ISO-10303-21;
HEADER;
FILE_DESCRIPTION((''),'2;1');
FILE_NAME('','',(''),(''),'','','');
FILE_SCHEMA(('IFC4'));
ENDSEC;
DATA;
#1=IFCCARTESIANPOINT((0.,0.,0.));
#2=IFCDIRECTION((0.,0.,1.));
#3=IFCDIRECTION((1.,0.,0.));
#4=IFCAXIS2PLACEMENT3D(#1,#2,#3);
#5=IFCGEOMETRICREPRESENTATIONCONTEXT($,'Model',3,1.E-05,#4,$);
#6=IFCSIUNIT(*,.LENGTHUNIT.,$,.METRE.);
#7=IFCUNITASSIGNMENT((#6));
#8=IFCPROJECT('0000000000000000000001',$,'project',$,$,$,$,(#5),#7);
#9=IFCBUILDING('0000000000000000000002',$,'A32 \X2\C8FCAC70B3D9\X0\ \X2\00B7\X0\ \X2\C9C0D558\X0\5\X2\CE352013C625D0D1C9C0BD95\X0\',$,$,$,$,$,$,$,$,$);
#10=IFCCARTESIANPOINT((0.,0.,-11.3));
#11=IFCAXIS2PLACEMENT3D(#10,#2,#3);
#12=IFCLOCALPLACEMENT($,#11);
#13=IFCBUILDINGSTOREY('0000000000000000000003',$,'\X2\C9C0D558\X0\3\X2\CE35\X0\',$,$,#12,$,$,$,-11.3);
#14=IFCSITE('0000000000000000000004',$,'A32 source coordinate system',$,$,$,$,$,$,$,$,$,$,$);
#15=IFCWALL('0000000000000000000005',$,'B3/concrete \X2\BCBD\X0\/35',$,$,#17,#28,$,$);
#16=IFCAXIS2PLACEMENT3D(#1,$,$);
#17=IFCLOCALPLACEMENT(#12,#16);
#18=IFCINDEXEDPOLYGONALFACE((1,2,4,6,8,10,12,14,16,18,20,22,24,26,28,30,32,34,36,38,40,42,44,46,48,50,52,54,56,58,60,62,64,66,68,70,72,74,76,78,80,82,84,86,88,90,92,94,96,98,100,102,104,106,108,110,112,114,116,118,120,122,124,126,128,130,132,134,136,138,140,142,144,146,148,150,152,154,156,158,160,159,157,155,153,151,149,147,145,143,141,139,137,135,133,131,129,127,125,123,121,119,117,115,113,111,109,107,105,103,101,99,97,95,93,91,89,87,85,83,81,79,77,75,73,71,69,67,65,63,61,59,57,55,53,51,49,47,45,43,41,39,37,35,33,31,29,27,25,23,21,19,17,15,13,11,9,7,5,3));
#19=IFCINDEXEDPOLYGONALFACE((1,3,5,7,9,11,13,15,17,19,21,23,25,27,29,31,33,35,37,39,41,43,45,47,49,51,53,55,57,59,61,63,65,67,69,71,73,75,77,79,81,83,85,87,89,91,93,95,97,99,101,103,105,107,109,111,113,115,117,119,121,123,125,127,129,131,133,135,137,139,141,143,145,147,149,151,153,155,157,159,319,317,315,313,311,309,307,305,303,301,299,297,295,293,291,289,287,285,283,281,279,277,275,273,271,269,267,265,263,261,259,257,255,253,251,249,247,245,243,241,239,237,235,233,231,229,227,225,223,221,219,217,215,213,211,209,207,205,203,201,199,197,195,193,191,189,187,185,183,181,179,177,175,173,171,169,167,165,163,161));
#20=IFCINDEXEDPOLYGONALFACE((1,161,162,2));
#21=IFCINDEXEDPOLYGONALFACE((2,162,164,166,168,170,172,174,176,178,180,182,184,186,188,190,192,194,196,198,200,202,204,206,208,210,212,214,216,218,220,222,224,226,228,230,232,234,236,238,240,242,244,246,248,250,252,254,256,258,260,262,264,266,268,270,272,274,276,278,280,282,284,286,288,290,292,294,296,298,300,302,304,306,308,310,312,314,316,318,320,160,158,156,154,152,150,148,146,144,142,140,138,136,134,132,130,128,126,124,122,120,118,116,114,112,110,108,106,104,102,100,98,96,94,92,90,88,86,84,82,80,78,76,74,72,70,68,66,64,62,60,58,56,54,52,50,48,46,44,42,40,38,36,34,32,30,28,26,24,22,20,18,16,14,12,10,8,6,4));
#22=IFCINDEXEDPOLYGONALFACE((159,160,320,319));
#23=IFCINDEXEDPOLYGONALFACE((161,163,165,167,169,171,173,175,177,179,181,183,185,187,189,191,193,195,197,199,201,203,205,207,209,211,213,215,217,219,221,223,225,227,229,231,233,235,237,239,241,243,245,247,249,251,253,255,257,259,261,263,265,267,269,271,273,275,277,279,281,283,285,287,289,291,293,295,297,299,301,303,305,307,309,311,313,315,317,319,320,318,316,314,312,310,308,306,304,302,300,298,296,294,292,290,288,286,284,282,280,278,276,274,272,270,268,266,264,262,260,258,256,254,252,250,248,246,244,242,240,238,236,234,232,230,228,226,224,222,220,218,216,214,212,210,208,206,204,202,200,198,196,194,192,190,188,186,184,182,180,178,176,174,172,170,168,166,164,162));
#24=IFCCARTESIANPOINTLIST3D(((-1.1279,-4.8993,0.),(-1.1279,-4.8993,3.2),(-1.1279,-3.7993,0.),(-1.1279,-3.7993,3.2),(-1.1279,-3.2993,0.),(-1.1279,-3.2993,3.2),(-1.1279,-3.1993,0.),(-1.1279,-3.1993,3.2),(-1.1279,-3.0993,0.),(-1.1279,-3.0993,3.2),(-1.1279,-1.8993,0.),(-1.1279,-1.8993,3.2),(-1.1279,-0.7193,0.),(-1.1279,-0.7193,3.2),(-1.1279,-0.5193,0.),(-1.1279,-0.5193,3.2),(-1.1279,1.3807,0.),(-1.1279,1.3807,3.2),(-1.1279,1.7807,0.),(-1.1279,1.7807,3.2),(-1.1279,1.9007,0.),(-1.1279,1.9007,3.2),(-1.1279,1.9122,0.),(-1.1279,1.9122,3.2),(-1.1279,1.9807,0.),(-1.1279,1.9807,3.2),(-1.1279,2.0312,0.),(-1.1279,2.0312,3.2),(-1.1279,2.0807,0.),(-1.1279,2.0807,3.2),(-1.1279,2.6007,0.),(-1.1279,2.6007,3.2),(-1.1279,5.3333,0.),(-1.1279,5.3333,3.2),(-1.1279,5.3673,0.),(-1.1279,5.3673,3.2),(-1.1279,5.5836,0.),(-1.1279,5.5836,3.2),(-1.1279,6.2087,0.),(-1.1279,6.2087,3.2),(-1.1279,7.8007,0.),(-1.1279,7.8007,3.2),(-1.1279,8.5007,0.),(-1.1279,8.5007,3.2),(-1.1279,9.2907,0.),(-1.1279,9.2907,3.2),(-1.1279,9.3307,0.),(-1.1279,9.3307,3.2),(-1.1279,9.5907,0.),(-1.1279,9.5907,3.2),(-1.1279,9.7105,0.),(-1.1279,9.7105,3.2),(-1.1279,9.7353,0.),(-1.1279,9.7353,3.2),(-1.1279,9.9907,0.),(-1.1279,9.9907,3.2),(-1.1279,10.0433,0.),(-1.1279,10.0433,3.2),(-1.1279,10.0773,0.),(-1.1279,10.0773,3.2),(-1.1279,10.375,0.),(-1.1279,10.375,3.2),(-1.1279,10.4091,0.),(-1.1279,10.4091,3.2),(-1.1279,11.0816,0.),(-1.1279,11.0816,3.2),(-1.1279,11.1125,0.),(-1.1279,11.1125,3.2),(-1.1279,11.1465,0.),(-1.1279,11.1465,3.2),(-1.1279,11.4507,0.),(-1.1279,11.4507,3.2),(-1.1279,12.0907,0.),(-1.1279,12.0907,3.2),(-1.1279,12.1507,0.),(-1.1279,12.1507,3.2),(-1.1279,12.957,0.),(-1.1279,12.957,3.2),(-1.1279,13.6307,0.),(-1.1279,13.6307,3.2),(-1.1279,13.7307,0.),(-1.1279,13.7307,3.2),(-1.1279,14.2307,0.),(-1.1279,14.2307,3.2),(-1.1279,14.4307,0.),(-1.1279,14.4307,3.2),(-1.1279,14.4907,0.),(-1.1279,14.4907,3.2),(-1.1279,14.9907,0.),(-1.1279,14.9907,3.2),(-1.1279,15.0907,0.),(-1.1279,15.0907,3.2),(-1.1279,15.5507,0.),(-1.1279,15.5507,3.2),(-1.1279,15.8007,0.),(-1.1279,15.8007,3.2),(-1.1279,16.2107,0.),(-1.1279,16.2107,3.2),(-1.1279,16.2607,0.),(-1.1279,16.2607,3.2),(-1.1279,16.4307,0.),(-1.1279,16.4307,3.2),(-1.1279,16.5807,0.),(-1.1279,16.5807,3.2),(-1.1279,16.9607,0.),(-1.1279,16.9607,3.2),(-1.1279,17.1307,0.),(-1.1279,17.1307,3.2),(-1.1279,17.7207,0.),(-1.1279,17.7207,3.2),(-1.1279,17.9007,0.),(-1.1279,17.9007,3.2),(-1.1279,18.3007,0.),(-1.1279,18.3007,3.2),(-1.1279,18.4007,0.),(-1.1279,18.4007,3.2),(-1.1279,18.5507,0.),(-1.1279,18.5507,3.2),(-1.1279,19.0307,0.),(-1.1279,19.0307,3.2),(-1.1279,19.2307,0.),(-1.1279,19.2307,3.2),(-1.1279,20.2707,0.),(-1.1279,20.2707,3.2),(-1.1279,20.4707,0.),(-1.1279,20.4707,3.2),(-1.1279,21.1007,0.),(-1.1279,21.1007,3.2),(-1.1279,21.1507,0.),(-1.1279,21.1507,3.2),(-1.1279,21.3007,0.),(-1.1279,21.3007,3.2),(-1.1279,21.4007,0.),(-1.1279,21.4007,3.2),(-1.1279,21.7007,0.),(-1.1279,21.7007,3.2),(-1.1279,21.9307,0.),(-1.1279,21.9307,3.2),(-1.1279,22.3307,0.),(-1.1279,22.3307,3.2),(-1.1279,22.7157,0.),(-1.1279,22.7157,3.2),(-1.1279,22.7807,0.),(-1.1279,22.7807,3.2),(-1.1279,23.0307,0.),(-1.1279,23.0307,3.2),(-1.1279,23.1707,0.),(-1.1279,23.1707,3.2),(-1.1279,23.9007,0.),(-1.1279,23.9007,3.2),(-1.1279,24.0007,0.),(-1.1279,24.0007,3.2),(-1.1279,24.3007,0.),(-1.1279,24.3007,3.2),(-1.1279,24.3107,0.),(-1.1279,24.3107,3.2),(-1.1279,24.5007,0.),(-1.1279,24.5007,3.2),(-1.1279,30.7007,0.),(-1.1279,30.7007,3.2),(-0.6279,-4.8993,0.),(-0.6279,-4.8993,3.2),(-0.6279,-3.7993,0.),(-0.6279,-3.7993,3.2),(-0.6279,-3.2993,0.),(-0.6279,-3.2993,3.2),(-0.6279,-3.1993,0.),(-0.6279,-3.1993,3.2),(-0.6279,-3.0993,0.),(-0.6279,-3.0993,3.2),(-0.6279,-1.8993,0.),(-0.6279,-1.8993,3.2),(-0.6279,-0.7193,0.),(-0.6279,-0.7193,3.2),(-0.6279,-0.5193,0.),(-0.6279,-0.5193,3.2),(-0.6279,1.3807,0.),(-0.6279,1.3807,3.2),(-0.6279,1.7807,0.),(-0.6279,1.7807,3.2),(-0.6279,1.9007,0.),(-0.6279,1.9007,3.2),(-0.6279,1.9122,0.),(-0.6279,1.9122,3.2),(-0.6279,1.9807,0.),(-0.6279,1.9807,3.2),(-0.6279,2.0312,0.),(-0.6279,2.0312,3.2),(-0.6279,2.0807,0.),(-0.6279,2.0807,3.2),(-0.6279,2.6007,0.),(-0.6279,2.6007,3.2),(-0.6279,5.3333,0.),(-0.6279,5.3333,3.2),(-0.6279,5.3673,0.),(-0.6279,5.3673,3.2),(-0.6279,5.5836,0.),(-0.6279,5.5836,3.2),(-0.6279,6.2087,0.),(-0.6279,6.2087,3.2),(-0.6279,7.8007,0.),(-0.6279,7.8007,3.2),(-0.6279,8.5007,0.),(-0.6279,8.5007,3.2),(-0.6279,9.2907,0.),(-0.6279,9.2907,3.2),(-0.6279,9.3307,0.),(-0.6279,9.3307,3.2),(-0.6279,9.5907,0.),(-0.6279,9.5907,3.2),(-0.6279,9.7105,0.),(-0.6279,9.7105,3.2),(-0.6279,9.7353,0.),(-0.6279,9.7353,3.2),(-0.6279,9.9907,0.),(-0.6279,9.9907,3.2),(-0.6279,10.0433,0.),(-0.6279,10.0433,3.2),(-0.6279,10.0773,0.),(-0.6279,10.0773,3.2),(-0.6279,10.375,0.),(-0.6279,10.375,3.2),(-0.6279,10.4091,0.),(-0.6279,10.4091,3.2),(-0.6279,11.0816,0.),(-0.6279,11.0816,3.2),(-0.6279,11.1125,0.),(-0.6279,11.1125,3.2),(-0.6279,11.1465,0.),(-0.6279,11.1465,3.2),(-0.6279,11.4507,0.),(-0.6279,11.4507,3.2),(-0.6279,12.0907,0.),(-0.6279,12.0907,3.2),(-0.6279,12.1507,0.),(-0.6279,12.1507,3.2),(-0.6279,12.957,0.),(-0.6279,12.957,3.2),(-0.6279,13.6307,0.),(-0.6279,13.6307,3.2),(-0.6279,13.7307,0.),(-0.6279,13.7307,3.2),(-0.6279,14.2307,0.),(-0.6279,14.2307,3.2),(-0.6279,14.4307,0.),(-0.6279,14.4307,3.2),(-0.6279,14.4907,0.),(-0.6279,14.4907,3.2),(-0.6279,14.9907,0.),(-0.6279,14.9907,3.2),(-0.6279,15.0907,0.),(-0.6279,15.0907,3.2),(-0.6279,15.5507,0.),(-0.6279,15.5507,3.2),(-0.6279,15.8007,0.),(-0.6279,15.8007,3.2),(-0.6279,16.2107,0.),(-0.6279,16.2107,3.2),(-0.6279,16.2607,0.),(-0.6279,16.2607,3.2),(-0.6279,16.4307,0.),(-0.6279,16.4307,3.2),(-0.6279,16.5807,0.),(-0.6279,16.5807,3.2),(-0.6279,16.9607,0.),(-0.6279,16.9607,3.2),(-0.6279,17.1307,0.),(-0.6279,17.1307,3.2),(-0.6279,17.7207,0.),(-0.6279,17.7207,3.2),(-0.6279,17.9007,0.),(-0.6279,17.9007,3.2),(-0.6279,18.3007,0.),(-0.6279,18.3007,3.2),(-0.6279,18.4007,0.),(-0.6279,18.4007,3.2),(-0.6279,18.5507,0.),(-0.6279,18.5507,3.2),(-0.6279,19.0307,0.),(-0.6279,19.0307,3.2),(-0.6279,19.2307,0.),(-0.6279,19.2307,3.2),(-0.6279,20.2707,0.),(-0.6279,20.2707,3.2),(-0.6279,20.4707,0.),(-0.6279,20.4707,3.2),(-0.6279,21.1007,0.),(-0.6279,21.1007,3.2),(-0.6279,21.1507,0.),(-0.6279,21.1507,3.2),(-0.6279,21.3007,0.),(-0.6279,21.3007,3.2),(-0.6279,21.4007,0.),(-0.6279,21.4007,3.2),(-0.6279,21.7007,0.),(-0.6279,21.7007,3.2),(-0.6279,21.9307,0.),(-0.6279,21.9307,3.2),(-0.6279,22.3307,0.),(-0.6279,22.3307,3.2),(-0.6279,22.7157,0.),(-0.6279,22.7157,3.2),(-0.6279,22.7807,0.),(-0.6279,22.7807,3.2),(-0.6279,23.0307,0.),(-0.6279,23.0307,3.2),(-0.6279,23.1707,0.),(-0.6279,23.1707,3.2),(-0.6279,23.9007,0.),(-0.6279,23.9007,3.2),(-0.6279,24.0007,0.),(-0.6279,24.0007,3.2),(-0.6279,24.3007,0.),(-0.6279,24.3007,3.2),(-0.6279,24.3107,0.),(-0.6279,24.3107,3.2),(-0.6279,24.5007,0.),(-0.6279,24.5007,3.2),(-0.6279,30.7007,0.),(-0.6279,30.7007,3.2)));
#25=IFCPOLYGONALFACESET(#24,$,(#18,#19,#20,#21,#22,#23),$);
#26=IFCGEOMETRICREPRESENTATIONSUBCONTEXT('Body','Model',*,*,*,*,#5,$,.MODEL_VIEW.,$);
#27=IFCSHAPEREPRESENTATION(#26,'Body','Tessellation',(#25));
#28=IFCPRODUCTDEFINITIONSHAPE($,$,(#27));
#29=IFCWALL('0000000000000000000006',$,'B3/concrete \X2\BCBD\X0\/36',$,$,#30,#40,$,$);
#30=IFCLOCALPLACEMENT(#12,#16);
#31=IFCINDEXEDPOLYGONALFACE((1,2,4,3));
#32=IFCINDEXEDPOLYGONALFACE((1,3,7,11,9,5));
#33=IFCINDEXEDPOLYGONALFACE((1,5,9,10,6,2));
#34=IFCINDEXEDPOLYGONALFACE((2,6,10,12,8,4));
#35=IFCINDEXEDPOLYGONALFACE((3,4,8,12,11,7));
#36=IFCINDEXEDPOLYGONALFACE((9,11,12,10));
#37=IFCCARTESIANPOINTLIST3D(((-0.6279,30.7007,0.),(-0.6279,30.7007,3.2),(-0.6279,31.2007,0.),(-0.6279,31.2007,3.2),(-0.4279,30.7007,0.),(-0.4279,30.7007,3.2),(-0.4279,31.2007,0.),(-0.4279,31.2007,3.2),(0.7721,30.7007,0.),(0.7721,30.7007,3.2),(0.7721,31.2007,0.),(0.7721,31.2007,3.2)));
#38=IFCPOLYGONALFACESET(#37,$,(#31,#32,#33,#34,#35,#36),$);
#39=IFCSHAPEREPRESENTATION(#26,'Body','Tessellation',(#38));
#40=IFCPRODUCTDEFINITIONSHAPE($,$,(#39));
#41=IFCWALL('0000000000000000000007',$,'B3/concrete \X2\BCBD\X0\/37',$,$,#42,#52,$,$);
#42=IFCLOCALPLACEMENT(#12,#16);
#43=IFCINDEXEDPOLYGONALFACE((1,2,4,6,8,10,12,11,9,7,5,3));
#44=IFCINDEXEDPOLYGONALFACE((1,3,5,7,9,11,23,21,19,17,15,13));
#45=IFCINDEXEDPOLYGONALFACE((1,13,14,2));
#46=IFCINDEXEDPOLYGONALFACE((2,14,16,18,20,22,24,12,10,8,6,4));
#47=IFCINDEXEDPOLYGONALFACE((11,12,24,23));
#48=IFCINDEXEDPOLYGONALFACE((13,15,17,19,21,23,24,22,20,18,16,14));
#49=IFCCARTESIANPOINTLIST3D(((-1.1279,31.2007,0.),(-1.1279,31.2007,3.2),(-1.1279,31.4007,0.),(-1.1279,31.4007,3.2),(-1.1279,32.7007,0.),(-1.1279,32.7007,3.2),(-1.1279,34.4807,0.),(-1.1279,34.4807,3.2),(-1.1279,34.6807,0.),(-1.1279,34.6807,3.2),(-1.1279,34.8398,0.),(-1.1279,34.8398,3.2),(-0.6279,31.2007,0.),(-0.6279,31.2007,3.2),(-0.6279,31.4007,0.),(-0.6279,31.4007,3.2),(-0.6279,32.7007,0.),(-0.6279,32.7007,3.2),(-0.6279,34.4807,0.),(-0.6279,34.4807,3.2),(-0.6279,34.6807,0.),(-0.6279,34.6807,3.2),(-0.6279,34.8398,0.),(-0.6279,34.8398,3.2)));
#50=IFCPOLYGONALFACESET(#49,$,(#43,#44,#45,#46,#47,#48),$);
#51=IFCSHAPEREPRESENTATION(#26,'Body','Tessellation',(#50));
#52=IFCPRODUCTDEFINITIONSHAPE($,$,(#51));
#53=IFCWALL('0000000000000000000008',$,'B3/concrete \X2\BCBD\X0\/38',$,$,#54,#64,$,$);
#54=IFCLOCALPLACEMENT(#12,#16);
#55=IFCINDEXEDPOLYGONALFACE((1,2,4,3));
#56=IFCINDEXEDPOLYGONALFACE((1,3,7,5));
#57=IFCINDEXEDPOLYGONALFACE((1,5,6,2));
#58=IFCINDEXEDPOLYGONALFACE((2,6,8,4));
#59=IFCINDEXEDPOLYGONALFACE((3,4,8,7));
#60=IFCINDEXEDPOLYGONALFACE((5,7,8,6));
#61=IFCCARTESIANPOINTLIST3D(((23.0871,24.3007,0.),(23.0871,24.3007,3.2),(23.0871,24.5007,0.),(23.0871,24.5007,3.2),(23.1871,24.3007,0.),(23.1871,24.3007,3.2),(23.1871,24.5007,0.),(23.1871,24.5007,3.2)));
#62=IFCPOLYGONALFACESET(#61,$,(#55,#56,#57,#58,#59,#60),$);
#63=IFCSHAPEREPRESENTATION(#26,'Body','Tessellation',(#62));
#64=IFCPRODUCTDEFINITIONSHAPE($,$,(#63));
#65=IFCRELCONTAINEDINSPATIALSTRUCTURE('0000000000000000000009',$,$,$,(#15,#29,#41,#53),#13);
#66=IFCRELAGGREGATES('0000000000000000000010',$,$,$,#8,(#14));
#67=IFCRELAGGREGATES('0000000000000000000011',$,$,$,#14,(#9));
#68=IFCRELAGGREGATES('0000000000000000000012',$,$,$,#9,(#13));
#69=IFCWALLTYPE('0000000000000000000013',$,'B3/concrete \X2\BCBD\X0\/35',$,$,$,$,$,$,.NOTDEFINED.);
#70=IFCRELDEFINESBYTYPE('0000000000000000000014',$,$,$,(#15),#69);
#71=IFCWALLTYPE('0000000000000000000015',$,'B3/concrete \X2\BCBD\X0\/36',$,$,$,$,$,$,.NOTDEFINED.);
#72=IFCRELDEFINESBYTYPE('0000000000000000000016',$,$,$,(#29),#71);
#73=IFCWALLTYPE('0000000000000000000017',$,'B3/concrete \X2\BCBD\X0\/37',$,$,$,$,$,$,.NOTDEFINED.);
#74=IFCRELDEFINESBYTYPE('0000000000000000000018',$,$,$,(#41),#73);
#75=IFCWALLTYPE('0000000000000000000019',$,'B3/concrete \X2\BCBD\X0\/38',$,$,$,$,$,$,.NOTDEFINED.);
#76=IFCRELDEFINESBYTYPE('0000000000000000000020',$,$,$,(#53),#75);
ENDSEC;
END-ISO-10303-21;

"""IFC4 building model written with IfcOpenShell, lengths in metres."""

from ifc_helpers import new_model, si_unit, frame, origin, origin_with_axes, place, context, subcontext, project, spatial, polyline, outline, extrude, source, transform, mapped, type_object, type_shapes, element, save


model = new_model("IFC4")

# Units and contexts
model_context = context("Model", 3, precision=1e-05, world=origin_with_axes())
body_context = subcontext(model_context, "Body", "Model", "MODEL_VIEW")
ifc_project = project(units=[si_unit("LENGTHUNIT", "METRE")], contexts=[model_context])

# Site, building, storey
site = spatial("IfcSite", under=ifc_project, Name="A32 source coordinate system")
building = spatial("IfcBuilding", under=site, Name="A32 주거동 · 지하5층–옥탑지붕")
storey_placement = place(None, frame((0.0, 0.0, -11.3), z_axis=(0.0, 0.0, 1.0), x_axis=(1.0, 0.0, 0.0)))
storey = spatial("IfcBuildingStorey", under=building, at=storey_placement, Name="지하3층", Elevation=-11.3)

# Walls
wall_type_1 = type_object("IfcWallType", Name="B3/concrete 벽/35", PredefinedType="NOTDEFINED")
shared_shape_1 = source(origin(), body_context, "Body", "SweptSolid", [
    extrude(outline(polyline([(-1.1279, -3.2993), (-1.1279, -3.1993), (-1.1279, -3.0993), (-1.1279, -1.8993), (-1.1279, -0.7193), (-1.1279, -0.5193), (-1.1279, 1.3807), (-1.1279, 1.7807), (-1.1279, 1.9007), (-1.1279, 1.9122), (-1.1279, 1.9807), (-1.1279, 2.0312), (-1.1279, 2.0807), (-1.1279, 2.6007), (-1.1279, 5.3333), (-1.1279, 5.3673), (-1.1279, 5.5836), (-1.1279, 6.2087), (-1.1279, 7.8007), (-1.1279, 8.5007), (-1.1279, 9.2907), (-1.1279, 9.3307), (-1.1279, 9.5907), (-1.1279, 9.7105), (-1.1279, 9.7353), (-1.1279, 9.9907), (-1.1279, 10.0433), (-1.1279, 10.0773), (-1.1279, 10.375), (-1.1279, 10.4091), (-1.1279, 11.0816), (-1.1279, 11.1125), (-1.1279, 11.1465), (-1.1279, 11.4507), (-1.1279, 12.0907), (-1.1279, 12.1507), (-1.1279, 12.957), (-1.1279, 13.6307), (-1.1279, 13.7307), (-1.1279, 14.2307), (-1.1279, 14.4307), (-1.1279, 14.4907), (-1.1279, 14.9907), (-1.1279, 15.0907), (-1.1279, 15.5507), (-1.1279, 15.8007), (-1.1279, 16.2107), (-1.1279, 16.2607), (-1.1279, 16.4307), (-1.1279, 16.5807), (-1.1279, 16.9607), (-1.1279, 17.1307), (-1.1279, 17.7207), (-1.1279, 17.9007), (-1.1279, 18.3007), (-1.1279, 18.4007), (-1.1279, 18.5507), (-1.1279, 19.0307), (-1.1279, 19.2307), (-1.1279, 20.2707), (-1.1279, 20.4707), (-1.1279, 21.1007), (-1.1279, 21.1507), (-1.1279, 21.3007), (-1.1279, 21.4007), (-1.1279, 21.7007), (-1.1279, 21.9307), (-1.1279, 22.3307), (-1.1279, 22.7157), (-1.1279, 22.7807), (-1.1279, 23.0307), (-1.1279, 23.1707), (-1.1279, 23.9007), (-1.1279, 24.0007), (-1.1279, 24.3007), (-1.1279, 24.3107), (-1.1279, 24.5007), (-1.1279, 30.7007), (-0.6279, 30.7007), (-0.6279, 24.5007), (-0.6279, 24.3107), (-0.6279, 24.3007), (-0.6279, 24.0007), (-0.6279, 23.9007), (-0.6279, 23.1707), (-0.6279, 23.0307), (-0.6279, 22.7807), (-0.6279, 22.7157), (-0.6279, 22.3307), (-0.6279, 21.9307), (-0.6279, 21.7007), (-0.6279, 21.4007), (-0.6279, 21.3007), (-0.6279, 21.1507), (-0.6279, 21.1007), (-0.6279, 20.4707), (-0.6279, 20.2707), (-0.6279, 19.2307), (-0.6279, 19.0307), (-0.6279, 18.5507), (-0.6279, 18.4007), (-0.6279, 18.3007), (-0.6279, 17.9007), (-0.6279, 17.7207), (-0.6279, 17.1307), (-0.6279, 16.9607), (-0.6279, 16.5807), (-0.6279, 16.4307), (-0.6279, 16.2607), (-0.6279, 16.2107), (-0.6279, 15.8007), (-0.6279, 15.5507), (-0.6279, 15.0907), (-0.6279, 14.9907), (-0.6279, 14.4907), (-0.6279, 14.4307), (-0.6279, 14.2307), (-0.6279, 13.7307), (-0.6279, 13.6307), (-0.6279, 12.957), (-0.6279, 12.1507), (-0.6279, 12.0907), (-0.6279, 11.4507), (-0.6279, 11.1465), (-0.6279, 11.1125), (-0.6279, 11.0816), (-0.6279, 10.4091), (-0.6279, 10.375), (-0.6279, 10.0773), (-0.6279, 10.0433), (-0.6279, 9.9907), (-0.6279, 9.7353), (-0.6279, 9.7105), (-0.6279, 9.5907), (-0.6279, 9.3307), (-0.6279, 9.2907), (-0.6279, 8.5007), (-0.6279, 7.8007), (-0.6279, 6.2087), (-0.6279, 5.5836), (-0.6279, 5.3673), (-0.6279, 5.3333), (-0.6279, 2.6007), (-0.6279, 2.0807), (-0.6279, 2.0312), (-0.6279, 1.9807), (-0.6279, 1.9122), (-0.6279, 1.9007), (-0.6279, 1.7807), (-0.6279, 1.3807), (-0.6279, -0.5193), (-0.6279, -0.7193), (-0.6279, -1.8993), (-0.6279, -3.0993), (-0.6279, -3.1993), (-0.6279, -3.2993), (-0.6279, -3.7993), (-0.6279, -4.8993), (-1.1279, -4.8993), (-1.1279, -3.7993), (-1.1279, -3.2993)])), origin(), (0.0, 0.0, 1.0), 3.2),
])
type_shapes(wall_type_1, [shared_shape_1])
wall_1_placement = place(storey_placement, origin_with_axes())
element("IfcWall", 1, at=wall_1_placement, inside=storey, type_object=wall_type_1, Name="B3/concrete 벽/35", context=body_context, shape_type="MappedRepresentation", body=[
    mapped(shared_shape_1, transform((0.0, 0.0, 0.0), scale=1.0)),
])
wall_type_2 = type_object("IfcWallType", Name="B3/concrete 벽/36", PredefinedType="NOTDEFINED")
shared_shape_2 = source(origin(), body_context, "Body", "SweptSolid", [
    extrude(outline(polyline([(0.7721, 31.2007), (0.7721, 30.7007), (-0.4279, 30.7007), (-0.6279, 30.7007), (-0.6279, 31.2007), (-0.4279, 31.2007), (0.7721, 31.2007)])), origin(), (0.0, 0.0, 1.0), 3.2),
])
type_shapes(wall_type_2, [shared_shape_2])
wall_2_placement = place(storey_placement, origin_with_axes())
element("IfcWall", 2, at=wall_2_placement, inside=storey, type_object=wall_type_2, Name="B3/concrete 벽/36", context=body_context, shape_type="MappedRepresentation", body=[
    mapped(shared_shape_2, transform((0.0, 0.0, 0.0), scale=1.0)),
])
wall_type_3 = type_object("IfcWallType", Name="B3/concrete 벽/37", PredefinedType="NOTDEFINED")
shared_shape_3 = source(origin(), body_context, "Body", "SweptSolid", [
    extrude(outline(polyline([(-1.1279, 32.7007), (-1.1279, 34.4807), (-1.1279, 34.6807), (-1.1279, 34.8398), (-0.6279, 34.8398), (-0.6279, 34.6807), (-0.6279, 34.4807), (-0.6279, 32.7007), (-0.6279, 31.4007), (-0.6279, 31.2007), (-1.1279, 31.2007), (-1.1279, 31.4007), (-1.1279, 32.7007)])), origin(), (0.0, 0.0, 1.0), 3.2),
])
type_shapes(wall_type_3, [shared_shape_3])
wall_3_placement = place(storey_placement, origin_with_axes())
element("IfcWall", 3, at=wall_3_placement, inside=storey, type_object=wall_type_3, Name="B3/concrete 벽/37", context=body_context, shape_type="MappedRepresentation", body=[
    mapped(shared_shape_3, transform((0.0, 0.0, 0.0), scale=1.0)),
])
wall_type_4 = type_object("IfcWallType", Name="B3/concrete 벽/38", PredefinedType="NOTDEFINED")
shared_shape_4 = source(origin(), body_context, "Body", "SweptSolid", [
    extrude(outline(polyline([(23.0871, 24.3007), (23.0871, 24.5007), (23.1871, 24.5007), (23.1871, 24.3007), (23.0871, 24.3007)])), origin(), (0.0, 0.0, 1.0), 3.2),
])
type_shapes(wall_type_4, [shared_shape_4])
wall_4_placement = place(storey_placement, origin_with_axes())
element("IfcWall", 4, at=wall_4_placement, inside=storey, type_object=wall_type_4, Name="B3/concrete 벽/38", context=body_context, shape_type="MappedRepresentation", body=[
    mapped(shared_shape_4, transform((0.0, 0.0, 0.0), scale=1.0)),
])

save(model, "model.ifc")
